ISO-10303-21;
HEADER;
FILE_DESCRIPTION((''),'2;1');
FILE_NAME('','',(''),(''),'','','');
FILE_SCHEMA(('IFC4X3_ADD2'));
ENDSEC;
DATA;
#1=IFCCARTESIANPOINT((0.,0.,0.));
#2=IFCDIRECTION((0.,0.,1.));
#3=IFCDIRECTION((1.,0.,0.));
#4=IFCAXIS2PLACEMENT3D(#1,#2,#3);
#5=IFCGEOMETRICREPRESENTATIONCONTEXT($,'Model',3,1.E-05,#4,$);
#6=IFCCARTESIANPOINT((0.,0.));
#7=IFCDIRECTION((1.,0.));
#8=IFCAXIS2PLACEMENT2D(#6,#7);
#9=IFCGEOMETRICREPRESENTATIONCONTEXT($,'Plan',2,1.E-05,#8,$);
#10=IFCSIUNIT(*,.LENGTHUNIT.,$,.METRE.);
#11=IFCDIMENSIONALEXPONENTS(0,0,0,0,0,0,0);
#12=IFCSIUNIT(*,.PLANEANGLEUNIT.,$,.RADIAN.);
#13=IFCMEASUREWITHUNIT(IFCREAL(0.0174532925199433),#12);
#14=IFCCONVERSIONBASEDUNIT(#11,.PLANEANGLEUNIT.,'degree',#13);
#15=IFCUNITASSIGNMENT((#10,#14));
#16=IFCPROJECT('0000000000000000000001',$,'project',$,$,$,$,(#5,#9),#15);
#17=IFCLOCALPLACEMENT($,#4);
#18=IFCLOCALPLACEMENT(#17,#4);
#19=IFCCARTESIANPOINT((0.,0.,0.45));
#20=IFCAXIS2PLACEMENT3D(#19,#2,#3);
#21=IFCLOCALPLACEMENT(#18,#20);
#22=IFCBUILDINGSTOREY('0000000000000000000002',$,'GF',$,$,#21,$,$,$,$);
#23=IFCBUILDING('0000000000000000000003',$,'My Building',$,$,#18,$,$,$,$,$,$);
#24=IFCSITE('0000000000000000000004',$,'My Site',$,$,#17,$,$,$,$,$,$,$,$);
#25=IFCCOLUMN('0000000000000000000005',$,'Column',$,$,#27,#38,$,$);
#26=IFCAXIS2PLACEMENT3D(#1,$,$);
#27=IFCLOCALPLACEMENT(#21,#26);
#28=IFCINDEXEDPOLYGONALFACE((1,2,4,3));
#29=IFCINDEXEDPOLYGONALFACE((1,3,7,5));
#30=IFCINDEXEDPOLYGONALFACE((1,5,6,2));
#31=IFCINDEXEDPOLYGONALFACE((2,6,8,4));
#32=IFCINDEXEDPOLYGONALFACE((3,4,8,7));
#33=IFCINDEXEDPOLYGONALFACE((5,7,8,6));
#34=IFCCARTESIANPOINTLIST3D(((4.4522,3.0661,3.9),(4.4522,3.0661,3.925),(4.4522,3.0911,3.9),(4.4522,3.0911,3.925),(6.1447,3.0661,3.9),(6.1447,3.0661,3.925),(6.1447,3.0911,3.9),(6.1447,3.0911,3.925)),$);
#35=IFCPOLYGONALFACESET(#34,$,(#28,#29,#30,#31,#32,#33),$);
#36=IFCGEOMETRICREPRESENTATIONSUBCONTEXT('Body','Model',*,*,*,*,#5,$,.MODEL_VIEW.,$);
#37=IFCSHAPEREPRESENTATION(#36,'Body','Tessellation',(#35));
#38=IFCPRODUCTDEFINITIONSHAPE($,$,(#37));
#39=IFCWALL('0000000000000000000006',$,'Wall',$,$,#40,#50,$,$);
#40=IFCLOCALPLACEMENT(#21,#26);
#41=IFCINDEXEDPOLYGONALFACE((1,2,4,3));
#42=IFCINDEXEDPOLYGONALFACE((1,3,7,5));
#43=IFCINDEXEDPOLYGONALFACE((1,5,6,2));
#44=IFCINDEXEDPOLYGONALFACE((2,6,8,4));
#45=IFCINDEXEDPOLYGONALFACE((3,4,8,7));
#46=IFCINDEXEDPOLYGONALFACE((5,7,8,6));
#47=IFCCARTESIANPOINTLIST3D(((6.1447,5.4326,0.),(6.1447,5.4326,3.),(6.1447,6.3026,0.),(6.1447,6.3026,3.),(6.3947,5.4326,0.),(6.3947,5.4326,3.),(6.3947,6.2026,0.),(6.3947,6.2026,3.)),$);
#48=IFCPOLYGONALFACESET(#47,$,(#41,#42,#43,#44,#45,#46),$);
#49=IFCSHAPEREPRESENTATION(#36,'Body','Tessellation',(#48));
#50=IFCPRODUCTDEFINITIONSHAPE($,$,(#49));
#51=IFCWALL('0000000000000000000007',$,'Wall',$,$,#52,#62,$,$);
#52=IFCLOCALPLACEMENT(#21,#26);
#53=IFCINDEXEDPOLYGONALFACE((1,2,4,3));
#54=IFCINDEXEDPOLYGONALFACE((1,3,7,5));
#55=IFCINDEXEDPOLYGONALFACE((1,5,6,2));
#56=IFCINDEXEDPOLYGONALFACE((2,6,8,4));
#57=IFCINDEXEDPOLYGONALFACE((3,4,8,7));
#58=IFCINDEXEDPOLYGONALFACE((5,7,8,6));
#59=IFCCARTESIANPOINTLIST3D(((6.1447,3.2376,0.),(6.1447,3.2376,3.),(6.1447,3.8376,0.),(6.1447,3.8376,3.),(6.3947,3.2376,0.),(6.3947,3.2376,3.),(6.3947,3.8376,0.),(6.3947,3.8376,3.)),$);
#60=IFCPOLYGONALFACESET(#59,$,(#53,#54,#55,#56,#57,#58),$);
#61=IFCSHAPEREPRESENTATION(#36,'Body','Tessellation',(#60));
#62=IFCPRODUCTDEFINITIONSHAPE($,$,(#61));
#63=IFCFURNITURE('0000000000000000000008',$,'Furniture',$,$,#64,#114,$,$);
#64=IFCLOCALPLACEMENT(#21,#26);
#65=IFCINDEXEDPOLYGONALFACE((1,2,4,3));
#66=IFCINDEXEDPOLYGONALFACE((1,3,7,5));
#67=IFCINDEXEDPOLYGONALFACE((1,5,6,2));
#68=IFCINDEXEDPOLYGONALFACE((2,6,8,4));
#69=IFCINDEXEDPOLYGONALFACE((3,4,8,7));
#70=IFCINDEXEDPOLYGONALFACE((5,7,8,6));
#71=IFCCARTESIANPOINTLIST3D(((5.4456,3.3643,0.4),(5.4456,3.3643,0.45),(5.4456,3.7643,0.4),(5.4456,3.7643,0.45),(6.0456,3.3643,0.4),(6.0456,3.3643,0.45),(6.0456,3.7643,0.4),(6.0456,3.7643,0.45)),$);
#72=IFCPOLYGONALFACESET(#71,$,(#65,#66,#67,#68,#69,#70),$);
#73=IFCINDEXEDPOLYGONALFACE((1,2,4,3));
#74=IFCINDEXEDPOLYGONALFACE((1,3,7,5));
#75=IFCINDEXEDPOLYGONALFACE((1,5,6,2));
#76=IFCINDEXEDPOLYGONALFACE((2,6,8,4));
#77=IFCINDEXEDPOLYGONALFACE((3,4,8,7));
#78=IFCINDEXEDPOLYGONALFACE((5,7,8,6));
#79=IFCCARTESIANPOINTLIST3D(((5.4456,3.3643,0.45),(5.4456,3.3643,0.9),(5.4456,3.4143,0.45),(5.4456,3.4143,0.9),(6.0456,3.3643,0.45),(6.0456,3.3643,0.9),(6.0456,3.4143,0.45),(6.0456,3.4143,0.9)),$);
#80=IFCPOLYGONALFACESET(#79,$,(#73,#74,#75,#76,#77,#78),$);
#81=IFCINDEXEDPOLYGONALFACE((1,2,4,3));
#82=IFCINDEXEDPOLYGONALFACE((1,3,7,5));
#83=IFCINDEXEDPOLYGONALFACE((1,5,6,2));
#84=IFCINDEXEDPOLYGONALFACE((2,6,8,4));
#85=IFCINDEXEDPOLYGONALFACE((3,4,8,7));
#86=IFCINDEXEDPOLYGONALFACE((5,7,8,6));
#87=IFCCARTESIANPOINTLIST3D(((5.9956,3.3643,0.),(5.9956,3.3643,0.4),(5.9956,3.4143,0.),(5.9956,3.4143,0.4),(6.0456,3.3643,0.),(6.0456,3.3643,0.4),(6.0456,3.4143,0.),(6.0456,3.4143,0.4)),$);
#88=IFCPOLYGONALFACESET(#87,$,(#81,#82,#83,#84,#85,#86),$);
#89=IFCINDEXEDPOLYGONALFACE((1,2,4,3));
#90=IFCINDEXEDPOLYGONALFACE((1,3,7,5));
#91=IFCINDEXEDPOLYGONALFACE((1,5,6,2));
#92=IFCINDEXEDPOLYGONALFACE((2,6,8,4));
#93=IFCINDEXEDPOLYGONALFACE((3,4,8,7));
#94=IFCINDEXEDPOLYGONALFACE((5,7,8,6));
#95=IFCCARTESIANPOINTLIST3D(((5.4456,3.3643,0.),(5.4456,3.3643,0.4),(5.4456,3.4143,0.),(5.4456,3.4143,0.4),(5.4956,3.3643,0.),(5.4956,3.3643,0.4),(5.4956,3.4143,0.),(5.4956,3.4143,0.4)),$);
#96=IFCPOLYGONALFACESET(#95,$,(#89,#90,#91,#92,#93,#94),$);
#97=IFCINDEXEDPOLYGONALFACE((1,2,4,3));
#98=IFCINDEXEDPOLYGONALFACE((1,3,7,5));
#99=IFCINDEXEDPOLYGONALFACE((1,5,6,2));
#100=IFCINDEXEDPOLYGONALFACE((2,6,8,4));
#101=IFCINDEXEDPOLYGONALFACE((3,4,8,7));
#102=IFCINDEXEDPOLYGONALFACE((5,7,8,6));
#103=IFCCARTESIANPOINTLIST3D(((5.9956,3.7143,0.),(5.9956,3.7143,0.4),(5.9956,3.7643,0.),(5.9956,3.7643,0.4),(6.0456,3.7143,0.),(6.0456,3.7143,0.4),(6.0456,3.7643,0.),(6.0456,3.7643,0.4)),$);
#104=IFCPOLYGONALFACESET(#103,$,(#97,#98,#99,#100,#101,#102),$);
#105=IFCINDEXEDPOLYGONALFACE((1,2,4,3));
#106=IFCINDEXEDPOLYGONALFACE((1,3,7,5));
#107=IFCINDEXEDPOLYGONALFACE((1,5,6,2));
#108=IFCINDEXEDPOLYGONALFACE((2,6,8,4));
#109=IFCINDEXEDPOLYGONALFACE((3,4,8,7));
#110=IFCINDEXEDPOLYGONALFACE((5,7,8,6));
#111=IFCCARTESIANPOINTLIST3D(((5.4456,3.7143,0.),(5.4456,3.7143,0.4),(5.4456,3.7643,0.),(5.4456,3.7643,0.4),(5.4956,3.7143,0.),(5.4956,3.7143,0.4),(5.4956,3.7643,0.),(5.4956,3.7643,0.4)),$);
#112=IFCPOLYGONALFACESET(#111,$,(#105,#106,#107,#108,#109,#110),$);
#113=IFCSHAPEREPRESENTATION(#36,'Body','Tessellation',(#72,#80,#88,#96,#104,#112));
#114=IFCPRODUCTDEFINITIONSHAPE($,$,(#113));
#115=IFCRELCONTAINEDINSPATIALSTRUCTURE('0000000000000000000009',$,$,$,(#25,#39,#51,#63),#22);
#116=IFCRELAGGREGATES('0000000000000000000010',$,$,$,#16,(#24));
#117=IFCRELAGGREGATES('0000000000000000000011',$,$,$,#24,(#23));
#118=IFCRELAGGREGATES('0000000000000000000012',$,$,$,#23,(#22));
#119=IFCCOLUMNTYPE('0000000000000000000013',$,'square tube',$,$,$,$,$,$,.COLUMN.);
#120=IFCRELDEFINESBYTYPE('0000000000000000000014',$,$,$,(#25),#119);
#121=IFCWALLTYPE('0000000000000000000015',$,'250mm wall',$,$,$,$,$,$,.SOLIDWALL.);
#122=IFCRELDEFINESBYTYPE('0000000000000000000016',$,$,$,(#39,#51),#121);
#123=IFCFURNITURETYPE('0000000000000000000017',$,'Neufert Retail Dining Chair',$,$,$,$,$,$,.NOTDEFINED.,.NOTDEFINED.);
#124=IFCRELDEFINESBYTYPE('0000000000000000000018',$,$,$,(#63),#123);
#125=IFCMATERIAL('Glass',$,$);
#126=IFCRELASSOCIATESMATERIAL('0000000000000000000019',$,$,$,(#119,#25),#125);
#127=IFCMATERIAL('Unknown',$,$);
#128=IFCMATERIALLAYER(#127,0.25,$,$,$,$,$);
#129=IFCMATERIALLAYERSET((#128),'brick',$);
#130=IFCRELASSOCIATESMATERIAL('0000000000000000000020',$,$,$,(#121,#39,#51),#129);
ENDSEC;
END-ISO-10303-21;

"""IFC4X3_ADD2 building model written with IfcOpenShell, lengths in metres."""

from ifc_helpers import new_model, entity, si_unit, converted_unit, frame, origin_with_axes, origin_2d_with_axis, place, context, subcontext, project, spatial, line, indexed_curve, rectangle, outline, extrude, shape, source, transform, mapped, material, layer, layer_set, layer_usage, material_profile, profile_set, profile_usage, type_object, type_shapes, element, save


model = new_model("IFC4X3_ADD2")

# Units and contexts
model_context = context("Model", 3, precision=1e-05, world=origin_with_axes())
plan_context = context("Plan", 2, precision=1e-05, world=origin_2d_with_axis())
body_context_1 = subcontext(model_context, "Body", "Model", "MODEL_VIEW")
body_context_2 = subcontext(plan_context, "Body", "Plan", "PLAN_VIEW")
ifc_project = project(units=[si_unit("LENGTHUNIT", "METRE"), converted_unit("PLANEANGLEUNIT", "degree", entity("IfcReal", 0.0174532925199433), si_unit("PLANEANGLEUNIT", "RADIAN"), dimensions=[0, 0, 0, 0, 0, 0, 0])], contexts=[model_context, plan_context])

# Site, building, storey
site_placement = place(None, origin_with_axes())
site = spatial("IfcSite", under=ifc_project, at=site_placement, Name="My Site")
building_placement = place(site_placement, origin_with_axes())
building = spatial("IfcBuilding", under=site, at=building_placement, Name="My Building")
storey_placement = place(building_placement, frame((0.0, 0.0, 0.45), z_axis=(0.0, 0.0, 1.0), x_axis=(1.0, 0.0, 0.0)))
storey = spatial("IfcBuildingStorey", under=building, at=storey_placement, Name="GF")

# Column
ifc_material_1 = material(Name="Glass")
ifc_material_profile = material_profile(ifc_material_1, rectangle(XDim=0.025, YDim=0.025))
ifc_profile_set = profile_set([ifc_material_profile])
column_type = type_object("IfcColumnType", Name="square tube", PredefinedType="COLUMN", material=ifc_profile_set)
ifc_profile_usage_1 = profile_usage(ifc_profile_set, cardinal=5)
column_1_placement = place(storey_placement, frame((6.1447, 3.0786, 3.9125), z_axis=(-1.0, 0.0, 0.0), x_axis=(0.0, 0.0, -1.0)))
element("IfcColumn", 1, at=column_1_placement, inside=storey, type_object=column_type, material=ifc_profile_usage_1, Name="Column", context=body_context_1, shape_type="SweptSolid", body=[
    extrude(rectangle(XDim=0.025, YDim=0.025), origin_with_axes(), (0.0, 0.0, 1.0), 1.6925),
])

# Walls
ifc_material_2 = material(Name="Unknown")
ifc_layer = layer(ifc_material_2, 0.25)
ifc_layer_set = layer_set([ifc_layer], Name="brick")
ifc_layer_usage_1 = layer_usage(ifc_layer_set, "AXIS2", "POSITIVE", 0.0)
wall_type = type_object("IfcWallType", Name="250mm wall", PredefinedType="SOLIDWALL", material=ifc_layer_set)
wall_1_placement = place(storey_placement, frame((6.3947, 5.4326, 0.0), z_axis=(0.0, 0.0, 1.0), x_axis=(0.0, 1.0, 0.0)))
element("IfcWall", 2, at=wall_1_placement, inside=storey, type_object=wall_type, material=ifc_layer_usage_1, Name="Wall", context=body_context_1, shape_type="SweptSolid", body=[
    extrude(outline(indexed_curve([(0.0, 0.0), (0.0, 0.25), (0.87, 0.25), (0.77, 0.0)], segments=[line(1, 2, 3, 4, 1)])), origin_with_axes(), (0.0, 0.0, 1.0), 3.0),
])
ifc_layer_usage_2 = layer_usage(ifc_layer_set, "AXIS2", "POSITIVE", 0.0)
wall_2_placement = place(storey_placement, frame((6.3947, 3.2376, 0.0), z_axis=(0.0, 0.0, 1.0), x_axis=(0.0, 1.0, 0.0)))
element("IfcWall", 3, at=wall_2_placement, inside=storey, type_object=wall_type, material=ifc_layer_usage_2, Name="Wall", context=body_context_1, shape_type="SweptSolid", body=[
    extrude(outline(indexed_curve([(0.0, 0.0), (0.0, 0.25), (0.6, 0.25), (0.6, 0.0), (0.0, 0.0)], self_intersect=False)), origin_with_axes(), (0.0, 0.0, 1.0), 3.0),
])

# Furniture
furniture_type = type_object("IfcFurnitureType", Name="Neufert Retail Dining Chair", AssemblyPlace="NOTDEFINED", PredefinedType="NOTDEFINED")
shared_shape_1 = source(origin_with_axes(), body_context_1, "Body", "SweptSolid", [
    extrude(outline(indexed_curve([(-0.3, 0.0), (0.3, 0.0), (0.3, -0.4), (-0.3, -0.4)], segments=[line(1, 2, 3, 4, 1)])), frame((0.0, 0.0, 0.45), z_axis=(0.0, 0.0, 1.0), x_axis=(1.0, 0.0, 0.0)), (0.0, 0.0, -1.0), 0.05),
    extrude(outline(indexed_curve([(-0.3, 0.0), (0.3, 0.0), (0.3, -0.05), (-0.3, -0.05)], segments=[line(1, 2, 3, 4, 1)])), frame((0.0, 0.0, 0.9), z_axis=(0.0, 0.0, 1.0), x_axis=(1.0, 0.0, 0.0)), (0.0, 0.0, -1.0), 0.45),
    extrude(outline(indexed_curve([(-0.3, 0.0), (-0.25, 0.0), (-0.25, -0.05), (-0.3, -0.05)], segments=[line(1, 2, 3, 4, 1)])), origin_with_axes(), (0.0, 0.0, 1.0), 0.4),
    extrude(outline(indexed_curve([(0.3, 0.0), (0.25, 0.0), (0.25, -0.05), (0.3, -0.05)], segments=[line(1, 2, 3, 4, 1)])), origin_with_axes(), (0.0, 0.0, 1.0), 0.4),
    extrude(outline(indexed_curve([(-0.3, -0.4), (-0.25, -0.4), (-0.25, -0.35), (-0.3, -0.35)], segments=[line(1, 2, 3, 4, 1)])), origin_with_axes(), (0.0, 0.0, 1.0), 0.4),
    extrude(outline(indexed_curve([(0.3, -0.4), (0.25, -0.4), (0.25, -0.35), (0.3, -0.35)], segments=[line(1, 2, 3, 4, 1)])), origin_with_axes(), (0.0, 0.0, 1.0), 0.4),
])
shared_shape_2 = source(origin_with_axes(), body_context_2, "Body", "Curve2D", [
    entity("IfcIndexedPolyCurve", entity("IfcCartesianPointList2D", [[-0.3, -0.4], [0.3, -0.4]])),
    entity("IfcIndexedPolyCurve", entity("IfcCartesianPointList2D", [[-0.3, -0.4], [-0.3, -0.3], [-0.2121, -0.0879], [0.0, 0.0], [0.2121, -0.0879], [0.3, -0.3], [0.3, -0.4]]), [entity("IfcLineIndex", [1, 2]), entity("IfcArcIndex", [2, 3, 4]), entity("IfcArcIndex", [4, 5, 6]), entity("IfcLineIndex", [6, 7])]),
    entity("IfcIndexedPolyCurve", entity("IfcCartesianPointList2D", [[-0.26, -0.4], [-0.26, -0.3], [-0.1838, -0.1162], [0.0, -0.04], [0.1838, -0.1162], [0.26, -0.3], [0.26, -0.4]]), [entity("IfcLineIndex", [1, 2]), entity("IfcArcIndex", [2, 3, 4]), entity("IfcArcIndex", [4, 5, 6]), entity("IfcLineIndex", [6, 7])]),
])
type_shapes(furniture_type, [shared_shape_1, shared_shape_2])
furniture_placement = place(storey_placement, frame((5.7456, 3.3643, 0.0), z_axis=(0.0, 0.0, 1.0), x_axis=(-1.0, 0.000001, 0.0)))
element("IfcFurniture", 4, at=furniture_placement, inside=storey, type_object=furniture_type, Name="Furniture", shapes=[
    shape(body_context_1, "Body", "MappedRepresentation", [mapped(shared_shape_1, transform((0.0, 0.0, 0.0), x_axis=(1.0, 0.0, 0.0), y_axis=(0.0, 1.0, 0.0), z_axis=(0.0, 0.0, 1.0), scale=1.0))]),
    shape(body_context_2, "Body", "MappedRepresentation", [mapped(shared_shape_2, transform((0.0, 0.0, 0.0), x_axis=(1.0, 0.0, 0.0), y_axis=(0.0, 1.0, 0.0), z_axis=(0.0, 0.0, 1.0), scale=1.0))]),
])

save(model, "model.ifc")
